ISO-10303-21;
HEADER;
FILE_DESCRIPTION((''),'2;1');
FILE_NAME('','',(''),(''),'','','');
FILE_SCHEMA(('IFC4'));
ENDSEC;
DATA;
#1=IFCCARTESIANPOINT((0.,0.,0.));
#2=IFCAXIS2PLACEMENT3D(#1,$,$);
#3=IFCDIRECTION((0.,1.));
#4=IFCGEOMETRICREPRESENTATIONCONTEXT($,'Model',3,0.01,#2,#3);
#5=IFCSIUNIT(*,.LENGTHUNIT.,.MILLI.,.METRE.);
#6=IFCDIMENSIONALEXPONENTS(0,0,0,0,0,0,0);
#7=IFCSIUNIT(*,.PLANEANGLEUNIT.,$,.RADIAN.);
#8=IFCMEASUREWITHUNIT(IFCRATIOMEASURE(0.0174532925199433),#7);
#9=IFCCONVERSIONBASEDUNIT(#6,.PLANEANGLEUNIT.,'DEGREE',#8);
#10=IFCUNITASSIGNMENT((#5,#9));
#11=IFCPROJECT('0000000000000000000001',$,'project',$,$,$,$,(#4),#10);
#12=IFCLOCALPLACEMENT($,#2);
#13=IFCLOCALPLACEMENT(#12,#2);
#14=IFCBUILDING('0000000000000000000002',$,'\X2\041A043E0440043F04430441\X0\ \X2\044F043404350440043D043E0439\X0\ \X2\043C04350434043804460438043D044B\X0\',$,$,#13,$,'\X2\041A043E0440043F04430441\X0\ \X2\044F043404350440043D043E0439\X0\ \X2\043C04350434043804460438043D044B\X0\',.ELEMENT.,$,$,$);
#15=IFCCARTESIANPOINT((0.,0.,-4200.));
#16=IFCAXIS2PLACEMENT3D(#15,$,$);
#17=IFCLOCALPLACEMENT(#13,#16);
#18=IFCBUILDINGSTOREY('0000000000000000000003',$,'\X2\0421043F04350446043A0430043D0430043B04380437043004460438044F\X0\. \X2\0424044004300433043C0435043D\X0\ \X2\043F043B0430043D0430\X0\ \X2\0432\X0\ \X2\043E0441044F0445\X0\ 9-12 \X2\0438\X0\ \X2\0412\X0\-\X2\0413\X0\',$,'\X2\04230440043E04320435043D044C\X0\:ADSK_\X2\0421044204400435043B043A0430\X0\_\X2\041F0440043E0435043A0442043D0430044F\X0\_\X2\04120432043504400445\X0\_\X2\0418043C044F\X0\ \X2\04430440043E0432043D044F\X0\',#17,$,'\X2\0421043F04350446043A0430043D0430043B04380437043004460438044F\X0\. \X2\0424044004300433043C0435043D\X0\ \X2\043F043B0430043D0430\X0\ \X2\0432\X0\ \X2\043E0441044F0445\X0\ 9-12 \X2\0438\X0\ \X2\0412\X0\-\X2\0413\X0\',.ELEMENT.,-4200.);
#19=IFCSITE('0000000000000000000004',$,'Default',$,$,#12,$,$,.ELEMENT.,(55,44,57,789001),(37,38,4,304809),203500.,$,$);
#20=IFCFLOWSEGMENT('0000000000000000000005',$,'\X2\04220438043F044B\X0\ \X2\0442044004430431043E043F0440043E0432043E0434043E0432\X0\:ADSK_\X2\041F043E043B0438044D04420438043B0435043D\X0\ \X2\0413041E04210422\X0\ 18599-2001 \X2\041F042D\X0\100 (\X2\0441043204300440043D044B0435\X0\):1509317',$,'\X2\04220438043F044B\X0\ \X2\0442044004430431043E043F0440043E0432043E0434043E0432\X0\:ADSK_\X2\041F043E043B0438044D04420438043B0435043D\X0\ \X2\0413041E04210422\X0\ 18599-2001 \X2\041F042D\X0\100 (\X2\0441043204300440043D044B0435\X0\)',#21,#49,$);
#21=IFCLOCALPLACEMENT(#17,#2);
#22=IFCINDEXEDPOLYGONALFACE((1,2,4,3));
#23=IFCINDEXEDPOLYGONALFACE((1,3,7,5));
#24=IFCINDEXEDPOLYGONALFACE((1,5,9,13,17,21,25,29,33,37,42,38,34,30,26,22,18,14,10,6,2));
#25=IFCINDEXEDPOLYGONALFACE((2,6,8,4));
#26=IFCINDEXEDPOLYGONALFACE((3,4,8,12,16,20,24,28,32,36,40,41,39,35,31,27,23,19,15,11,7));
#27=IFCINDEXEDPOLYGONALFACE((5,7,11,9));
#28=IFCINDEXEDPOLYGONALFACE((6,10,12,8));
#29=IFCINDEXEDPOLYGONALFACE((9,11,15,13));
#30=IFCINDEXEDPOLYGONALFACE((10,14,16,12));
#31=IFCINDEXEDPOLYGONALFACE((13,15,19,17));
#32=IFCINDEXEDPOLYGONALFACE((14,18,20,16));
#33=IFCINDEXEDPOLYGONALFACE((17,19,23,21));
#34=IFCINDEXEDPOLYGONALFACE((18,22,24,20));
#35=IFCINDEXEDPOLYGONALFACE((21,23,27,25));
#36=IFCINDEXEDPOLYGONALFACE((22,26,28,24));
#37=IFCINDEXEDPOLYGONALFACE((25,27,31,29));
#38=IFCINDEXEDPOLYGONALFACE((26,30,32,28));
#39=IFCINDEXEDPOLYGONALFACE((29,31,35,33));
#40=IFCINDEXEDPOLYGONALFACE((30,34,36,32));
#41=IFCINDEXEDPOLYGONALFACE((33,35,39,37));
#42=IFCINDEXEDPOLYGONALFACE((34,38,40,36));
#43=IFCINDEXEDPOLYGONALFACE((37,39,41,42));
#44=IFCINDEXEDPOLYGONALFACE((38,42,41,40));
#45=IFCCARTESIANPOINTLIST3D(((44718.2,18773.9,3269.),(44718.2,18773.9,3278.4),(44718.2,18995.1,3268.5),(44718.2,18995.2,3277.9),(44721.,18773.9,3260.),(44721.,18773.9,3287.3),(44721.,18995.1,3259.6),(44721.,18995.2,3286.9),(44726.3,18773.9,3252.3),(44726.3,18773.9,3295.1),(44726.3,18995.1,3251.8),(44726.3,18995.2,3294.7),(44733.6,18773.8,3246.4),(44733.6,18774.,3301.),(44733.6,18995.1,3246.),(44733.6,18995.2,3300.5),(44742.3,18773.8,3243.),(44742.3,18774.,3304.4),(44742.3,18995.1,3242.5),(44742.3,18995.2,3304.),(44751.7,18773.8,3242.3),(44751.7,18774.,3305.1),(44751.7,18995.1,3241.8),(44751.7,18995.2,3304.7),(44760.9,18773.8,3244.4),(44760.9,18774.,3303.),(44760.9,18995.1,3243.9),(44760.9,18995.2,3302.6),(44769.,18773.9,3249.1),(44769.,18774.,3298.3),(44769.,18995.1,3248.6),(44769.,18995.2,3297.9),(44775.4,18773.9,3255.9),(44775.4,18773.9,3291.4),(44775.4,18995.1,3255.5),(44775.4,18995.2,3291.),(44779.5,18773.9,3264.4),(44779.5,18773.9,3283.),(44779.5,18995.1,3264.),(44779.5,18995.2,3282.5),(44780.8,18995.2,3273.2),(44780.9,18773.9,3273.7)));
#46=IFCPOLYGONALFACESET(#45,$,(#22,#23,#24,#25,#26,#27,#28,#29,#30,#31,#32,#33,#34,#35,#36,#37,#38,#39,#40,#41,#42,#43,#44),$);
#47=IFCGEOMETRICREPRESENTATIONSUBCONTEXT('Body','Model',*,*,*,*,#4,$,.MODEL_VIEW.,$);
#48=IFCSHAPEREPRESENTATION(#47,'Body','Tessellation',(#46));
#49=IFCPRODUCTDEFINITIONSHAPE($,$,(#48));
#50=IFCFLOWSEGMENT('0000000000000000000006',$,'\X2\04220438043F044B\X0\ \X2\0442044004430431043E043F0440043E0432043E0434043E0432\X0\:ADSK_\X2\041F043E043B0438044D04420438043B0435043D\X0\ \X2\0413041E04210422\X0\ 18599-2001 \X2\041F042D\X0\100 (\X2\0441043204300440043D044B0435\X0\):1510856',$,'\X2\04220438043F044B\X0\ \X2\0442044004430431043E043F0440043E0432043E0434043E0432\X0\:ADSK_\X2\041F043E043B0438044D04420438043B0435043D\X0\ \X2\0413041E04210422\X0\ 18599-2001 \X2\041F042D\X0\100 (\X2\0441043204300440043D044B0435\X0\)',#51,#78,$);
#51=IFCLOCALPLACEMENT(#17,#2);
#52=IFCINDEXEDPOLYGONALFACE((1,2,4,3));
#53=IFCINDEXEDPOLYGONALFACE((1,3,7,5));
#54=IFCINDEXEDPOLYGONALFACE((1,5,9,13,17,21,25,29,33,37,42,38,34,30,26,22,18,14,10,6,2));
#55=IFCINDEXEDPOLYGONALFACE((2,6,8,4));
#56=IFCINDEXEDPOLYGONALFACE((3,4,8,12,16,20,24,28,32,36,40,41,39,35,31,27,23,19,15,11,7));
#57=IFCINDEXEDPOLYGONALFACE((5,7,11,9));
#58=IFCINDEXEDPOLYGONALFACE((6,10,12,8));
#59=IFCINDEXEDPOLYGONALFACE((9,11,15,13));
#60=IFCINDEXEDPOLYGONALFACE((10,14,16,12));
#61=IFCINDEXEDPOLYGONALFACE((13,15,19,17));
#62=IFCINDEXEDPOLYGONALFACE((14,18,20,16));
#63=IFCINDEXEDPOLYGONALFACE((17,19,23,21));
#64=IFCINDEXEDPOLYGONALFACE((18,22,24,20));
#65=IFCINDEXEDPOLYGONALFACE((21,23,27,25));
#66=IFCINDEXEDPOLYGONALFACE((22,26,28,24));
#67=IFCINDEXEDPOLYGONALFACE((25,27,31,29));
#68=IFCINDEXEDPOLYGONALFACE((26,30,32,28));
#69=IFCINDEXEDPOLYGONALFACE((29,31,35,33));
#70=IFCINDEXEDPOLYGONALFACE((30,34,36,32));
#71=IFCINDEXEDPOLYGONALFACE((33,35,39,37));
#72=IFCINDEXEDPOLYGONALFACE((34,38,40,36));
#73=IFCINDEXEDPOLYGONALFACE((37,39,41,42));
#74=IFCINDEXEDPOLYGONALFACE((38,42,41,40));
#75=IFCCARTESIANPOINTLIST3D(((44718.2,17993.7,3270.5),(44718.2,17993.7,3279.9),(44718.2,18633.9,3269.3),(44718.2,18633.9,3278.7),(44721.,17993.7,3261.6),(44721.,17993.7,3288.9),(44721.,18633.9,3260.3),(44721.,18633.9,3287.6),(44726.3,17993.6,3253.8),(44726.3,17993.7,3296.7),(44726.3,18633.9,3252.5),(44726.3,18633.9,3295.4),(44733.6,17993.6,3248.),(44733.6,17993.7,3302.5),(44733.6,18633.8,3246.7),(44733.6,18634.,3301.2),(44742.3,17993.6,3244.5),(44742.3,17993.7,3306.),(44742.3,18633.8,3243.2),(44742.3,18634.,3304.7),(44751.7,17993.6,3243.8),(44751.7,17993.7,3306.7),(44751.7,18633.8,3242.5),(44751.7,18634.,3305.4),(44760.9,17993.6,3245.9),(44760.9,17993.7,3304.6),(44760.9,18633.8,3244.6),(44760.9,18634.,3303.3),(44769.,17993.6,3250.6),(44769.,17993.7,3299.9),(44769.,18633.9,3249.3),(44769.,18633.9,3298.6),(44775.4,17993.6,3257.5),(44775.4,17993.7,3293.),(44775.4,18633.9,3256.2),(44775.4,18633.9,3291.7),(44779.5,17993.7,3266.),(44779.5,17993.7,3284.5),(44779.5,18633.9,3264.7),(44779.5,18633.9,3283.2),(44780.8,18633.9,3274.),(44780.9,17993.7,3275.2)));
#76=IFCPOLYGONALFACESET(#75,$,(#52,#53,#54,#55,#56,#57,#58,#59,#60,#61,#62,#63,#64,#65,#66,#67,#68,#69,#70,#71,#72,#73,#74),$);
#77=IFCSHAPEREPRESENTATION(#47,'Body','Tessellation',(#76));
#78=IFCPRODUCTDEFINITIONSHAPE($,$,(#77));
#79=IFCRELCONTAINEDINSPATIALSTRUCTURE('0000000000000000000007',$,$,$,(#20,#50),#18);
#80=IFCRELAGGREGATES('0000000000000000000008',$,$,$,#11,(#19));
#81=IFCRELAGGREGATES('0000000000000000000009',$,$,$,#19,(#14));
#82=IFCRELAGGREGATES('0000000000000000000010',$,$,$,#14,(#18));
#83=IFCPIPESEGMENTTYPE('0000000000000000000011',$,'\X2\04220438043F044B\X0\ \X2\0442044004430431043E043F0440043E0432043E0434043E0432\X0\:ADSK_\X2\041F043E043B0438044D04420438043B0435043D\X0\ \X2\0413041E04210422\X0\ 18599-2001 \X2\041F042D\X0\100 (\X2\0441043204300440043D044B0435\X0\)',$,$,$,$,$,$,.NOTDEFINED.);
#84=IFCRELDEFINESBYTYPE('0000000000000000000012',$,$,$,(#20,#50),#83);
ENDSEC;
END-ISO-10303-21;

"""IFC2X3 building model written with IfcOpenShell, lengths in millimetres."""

from ifc_helpers import new_model, entity, si_unit, converted_unit, direction, frame, origin, origin_2d_with_axis, place, context, subcontext, project, spatial, circle, extrude, type_object, element, save


model = new_model("IFC2X3")

# Units and contexts
model_context = context("Model", 3, precision=0.01, world=origin(), true_north=direction((0.0, 1.0)))
body_context = subcontext(model_context, "Body", "Model", "MODEL_VIEW")
ifc_project = project(units=[si_unit("LENGTHUNIT", "METRE", prefix="MILLI"), converted_unit("PLANEANGLEUNIT", "DEGREE", entity("IfcRatioMeasure", 0.0174532925199433), si_unit("PLANEANGLEUNIT", "RADIAN"), dimensions=[0, 0, 0, 0, 0, 0, 0])], contexts=[model_context])

# Site, building, storey
site_placement = place(None, origin())
site = spatial("IfcSite", under=ifc_project, at=site_placement, Name="Default", CompositionType="ELEMENT", RefLatitude=(55, 44, 57, 789001), RefLongitude=(37, 38, 4, 304809), RefElevation=203500.0)
building_placement = place(site_placement, origin())
building = spatial("IfcBuilding", under=site, at=building_placement, Name="Корпус ядерной медицины", LongName="Корпус ядерной медицины", CompositionType="ELEMENT")
storey_placement = place(building_placement, frame((0.0, 0.0, -4200.0)))
storey = spatial("IfcBuildingStorey", under=building, at=storey_placement, Name="Спецканализация. Фрагмен плана в осях 9-12 и В-Г", ObjectType="Уровень:ADSK_Стрелка_Проектная_Вверх_Имя уровня", LongName="Спецканализация. Фрагмен плана в осях 9-12 и В-Г", CompositionType="ELEMENT", Elevation=-4200.0)

# Flow segments
pipe_segment_type = type_object("IfcPipeSegmentType", Name="Типы трубопроводов:ADSK_Полиэтилен ГОСТ 18599-2001 ПЭ100 (сварные)", PredefinedType="NOTDEFINED")
flow_segment_1_placement = place(storey_placement, frame((44716.2, 18773.8, 3240.1)))
element("IfcFlowSegment", 1, at=flow_segment_1_placement, inside=storey, type_object=pipe_segment_type, Name="Типы трубопроводов:ADSK_Полиэтилен ГОСТ 18599-2001 ПЭ100 (сварные):1509317", ObjectType="Типы трубопроводов:ADSK_Полиэтилен ГОСТ 18599-2001 ПЭ100 (сварные)", context=body_context, shape_type="SweptSolid", body=[
    extrude(circle(Radius=31.5, at=origin_2d_with_axis()), frame((33.1, 221.3, 33.1), z_axis=(0.0, -0.999998, 0.002), x_axis=(1.0, 0.0, 0.0)), (0.0, 0.0, 1.0), 221.2),
])
flow_segment_2_placement = place(storey_placement, frame((44716.2, 17993.6, 3240.9)))
element("IfcFlowSegment", 2, at=flow_segment_2_placement, inside=storey, type_object=pipe_segment_type, Name="Типы трубопроводов:ADSK_Полиэтилен ГОСТ 18599-2001 ПЭ100 (сварные):1510856", ObjectType="Типы трубопроводов:ADSK_Полиэтилен ГОСТ 18599-2001 ПЭ100 (сварные)", context=body_context, shape_type="SweptSolid", body=[
    extrude(circle(Radius=31.5, at=origin_2d_with_axis()), frame((33.1, 640.3, 33.1), z_axis=(0.0, -0.999998, 0.002), x_axis=(1.0, 0.0, 0.0)), (0.0, 0.0, 1.0), 640.2),
])

save(model, "model.ifc")
